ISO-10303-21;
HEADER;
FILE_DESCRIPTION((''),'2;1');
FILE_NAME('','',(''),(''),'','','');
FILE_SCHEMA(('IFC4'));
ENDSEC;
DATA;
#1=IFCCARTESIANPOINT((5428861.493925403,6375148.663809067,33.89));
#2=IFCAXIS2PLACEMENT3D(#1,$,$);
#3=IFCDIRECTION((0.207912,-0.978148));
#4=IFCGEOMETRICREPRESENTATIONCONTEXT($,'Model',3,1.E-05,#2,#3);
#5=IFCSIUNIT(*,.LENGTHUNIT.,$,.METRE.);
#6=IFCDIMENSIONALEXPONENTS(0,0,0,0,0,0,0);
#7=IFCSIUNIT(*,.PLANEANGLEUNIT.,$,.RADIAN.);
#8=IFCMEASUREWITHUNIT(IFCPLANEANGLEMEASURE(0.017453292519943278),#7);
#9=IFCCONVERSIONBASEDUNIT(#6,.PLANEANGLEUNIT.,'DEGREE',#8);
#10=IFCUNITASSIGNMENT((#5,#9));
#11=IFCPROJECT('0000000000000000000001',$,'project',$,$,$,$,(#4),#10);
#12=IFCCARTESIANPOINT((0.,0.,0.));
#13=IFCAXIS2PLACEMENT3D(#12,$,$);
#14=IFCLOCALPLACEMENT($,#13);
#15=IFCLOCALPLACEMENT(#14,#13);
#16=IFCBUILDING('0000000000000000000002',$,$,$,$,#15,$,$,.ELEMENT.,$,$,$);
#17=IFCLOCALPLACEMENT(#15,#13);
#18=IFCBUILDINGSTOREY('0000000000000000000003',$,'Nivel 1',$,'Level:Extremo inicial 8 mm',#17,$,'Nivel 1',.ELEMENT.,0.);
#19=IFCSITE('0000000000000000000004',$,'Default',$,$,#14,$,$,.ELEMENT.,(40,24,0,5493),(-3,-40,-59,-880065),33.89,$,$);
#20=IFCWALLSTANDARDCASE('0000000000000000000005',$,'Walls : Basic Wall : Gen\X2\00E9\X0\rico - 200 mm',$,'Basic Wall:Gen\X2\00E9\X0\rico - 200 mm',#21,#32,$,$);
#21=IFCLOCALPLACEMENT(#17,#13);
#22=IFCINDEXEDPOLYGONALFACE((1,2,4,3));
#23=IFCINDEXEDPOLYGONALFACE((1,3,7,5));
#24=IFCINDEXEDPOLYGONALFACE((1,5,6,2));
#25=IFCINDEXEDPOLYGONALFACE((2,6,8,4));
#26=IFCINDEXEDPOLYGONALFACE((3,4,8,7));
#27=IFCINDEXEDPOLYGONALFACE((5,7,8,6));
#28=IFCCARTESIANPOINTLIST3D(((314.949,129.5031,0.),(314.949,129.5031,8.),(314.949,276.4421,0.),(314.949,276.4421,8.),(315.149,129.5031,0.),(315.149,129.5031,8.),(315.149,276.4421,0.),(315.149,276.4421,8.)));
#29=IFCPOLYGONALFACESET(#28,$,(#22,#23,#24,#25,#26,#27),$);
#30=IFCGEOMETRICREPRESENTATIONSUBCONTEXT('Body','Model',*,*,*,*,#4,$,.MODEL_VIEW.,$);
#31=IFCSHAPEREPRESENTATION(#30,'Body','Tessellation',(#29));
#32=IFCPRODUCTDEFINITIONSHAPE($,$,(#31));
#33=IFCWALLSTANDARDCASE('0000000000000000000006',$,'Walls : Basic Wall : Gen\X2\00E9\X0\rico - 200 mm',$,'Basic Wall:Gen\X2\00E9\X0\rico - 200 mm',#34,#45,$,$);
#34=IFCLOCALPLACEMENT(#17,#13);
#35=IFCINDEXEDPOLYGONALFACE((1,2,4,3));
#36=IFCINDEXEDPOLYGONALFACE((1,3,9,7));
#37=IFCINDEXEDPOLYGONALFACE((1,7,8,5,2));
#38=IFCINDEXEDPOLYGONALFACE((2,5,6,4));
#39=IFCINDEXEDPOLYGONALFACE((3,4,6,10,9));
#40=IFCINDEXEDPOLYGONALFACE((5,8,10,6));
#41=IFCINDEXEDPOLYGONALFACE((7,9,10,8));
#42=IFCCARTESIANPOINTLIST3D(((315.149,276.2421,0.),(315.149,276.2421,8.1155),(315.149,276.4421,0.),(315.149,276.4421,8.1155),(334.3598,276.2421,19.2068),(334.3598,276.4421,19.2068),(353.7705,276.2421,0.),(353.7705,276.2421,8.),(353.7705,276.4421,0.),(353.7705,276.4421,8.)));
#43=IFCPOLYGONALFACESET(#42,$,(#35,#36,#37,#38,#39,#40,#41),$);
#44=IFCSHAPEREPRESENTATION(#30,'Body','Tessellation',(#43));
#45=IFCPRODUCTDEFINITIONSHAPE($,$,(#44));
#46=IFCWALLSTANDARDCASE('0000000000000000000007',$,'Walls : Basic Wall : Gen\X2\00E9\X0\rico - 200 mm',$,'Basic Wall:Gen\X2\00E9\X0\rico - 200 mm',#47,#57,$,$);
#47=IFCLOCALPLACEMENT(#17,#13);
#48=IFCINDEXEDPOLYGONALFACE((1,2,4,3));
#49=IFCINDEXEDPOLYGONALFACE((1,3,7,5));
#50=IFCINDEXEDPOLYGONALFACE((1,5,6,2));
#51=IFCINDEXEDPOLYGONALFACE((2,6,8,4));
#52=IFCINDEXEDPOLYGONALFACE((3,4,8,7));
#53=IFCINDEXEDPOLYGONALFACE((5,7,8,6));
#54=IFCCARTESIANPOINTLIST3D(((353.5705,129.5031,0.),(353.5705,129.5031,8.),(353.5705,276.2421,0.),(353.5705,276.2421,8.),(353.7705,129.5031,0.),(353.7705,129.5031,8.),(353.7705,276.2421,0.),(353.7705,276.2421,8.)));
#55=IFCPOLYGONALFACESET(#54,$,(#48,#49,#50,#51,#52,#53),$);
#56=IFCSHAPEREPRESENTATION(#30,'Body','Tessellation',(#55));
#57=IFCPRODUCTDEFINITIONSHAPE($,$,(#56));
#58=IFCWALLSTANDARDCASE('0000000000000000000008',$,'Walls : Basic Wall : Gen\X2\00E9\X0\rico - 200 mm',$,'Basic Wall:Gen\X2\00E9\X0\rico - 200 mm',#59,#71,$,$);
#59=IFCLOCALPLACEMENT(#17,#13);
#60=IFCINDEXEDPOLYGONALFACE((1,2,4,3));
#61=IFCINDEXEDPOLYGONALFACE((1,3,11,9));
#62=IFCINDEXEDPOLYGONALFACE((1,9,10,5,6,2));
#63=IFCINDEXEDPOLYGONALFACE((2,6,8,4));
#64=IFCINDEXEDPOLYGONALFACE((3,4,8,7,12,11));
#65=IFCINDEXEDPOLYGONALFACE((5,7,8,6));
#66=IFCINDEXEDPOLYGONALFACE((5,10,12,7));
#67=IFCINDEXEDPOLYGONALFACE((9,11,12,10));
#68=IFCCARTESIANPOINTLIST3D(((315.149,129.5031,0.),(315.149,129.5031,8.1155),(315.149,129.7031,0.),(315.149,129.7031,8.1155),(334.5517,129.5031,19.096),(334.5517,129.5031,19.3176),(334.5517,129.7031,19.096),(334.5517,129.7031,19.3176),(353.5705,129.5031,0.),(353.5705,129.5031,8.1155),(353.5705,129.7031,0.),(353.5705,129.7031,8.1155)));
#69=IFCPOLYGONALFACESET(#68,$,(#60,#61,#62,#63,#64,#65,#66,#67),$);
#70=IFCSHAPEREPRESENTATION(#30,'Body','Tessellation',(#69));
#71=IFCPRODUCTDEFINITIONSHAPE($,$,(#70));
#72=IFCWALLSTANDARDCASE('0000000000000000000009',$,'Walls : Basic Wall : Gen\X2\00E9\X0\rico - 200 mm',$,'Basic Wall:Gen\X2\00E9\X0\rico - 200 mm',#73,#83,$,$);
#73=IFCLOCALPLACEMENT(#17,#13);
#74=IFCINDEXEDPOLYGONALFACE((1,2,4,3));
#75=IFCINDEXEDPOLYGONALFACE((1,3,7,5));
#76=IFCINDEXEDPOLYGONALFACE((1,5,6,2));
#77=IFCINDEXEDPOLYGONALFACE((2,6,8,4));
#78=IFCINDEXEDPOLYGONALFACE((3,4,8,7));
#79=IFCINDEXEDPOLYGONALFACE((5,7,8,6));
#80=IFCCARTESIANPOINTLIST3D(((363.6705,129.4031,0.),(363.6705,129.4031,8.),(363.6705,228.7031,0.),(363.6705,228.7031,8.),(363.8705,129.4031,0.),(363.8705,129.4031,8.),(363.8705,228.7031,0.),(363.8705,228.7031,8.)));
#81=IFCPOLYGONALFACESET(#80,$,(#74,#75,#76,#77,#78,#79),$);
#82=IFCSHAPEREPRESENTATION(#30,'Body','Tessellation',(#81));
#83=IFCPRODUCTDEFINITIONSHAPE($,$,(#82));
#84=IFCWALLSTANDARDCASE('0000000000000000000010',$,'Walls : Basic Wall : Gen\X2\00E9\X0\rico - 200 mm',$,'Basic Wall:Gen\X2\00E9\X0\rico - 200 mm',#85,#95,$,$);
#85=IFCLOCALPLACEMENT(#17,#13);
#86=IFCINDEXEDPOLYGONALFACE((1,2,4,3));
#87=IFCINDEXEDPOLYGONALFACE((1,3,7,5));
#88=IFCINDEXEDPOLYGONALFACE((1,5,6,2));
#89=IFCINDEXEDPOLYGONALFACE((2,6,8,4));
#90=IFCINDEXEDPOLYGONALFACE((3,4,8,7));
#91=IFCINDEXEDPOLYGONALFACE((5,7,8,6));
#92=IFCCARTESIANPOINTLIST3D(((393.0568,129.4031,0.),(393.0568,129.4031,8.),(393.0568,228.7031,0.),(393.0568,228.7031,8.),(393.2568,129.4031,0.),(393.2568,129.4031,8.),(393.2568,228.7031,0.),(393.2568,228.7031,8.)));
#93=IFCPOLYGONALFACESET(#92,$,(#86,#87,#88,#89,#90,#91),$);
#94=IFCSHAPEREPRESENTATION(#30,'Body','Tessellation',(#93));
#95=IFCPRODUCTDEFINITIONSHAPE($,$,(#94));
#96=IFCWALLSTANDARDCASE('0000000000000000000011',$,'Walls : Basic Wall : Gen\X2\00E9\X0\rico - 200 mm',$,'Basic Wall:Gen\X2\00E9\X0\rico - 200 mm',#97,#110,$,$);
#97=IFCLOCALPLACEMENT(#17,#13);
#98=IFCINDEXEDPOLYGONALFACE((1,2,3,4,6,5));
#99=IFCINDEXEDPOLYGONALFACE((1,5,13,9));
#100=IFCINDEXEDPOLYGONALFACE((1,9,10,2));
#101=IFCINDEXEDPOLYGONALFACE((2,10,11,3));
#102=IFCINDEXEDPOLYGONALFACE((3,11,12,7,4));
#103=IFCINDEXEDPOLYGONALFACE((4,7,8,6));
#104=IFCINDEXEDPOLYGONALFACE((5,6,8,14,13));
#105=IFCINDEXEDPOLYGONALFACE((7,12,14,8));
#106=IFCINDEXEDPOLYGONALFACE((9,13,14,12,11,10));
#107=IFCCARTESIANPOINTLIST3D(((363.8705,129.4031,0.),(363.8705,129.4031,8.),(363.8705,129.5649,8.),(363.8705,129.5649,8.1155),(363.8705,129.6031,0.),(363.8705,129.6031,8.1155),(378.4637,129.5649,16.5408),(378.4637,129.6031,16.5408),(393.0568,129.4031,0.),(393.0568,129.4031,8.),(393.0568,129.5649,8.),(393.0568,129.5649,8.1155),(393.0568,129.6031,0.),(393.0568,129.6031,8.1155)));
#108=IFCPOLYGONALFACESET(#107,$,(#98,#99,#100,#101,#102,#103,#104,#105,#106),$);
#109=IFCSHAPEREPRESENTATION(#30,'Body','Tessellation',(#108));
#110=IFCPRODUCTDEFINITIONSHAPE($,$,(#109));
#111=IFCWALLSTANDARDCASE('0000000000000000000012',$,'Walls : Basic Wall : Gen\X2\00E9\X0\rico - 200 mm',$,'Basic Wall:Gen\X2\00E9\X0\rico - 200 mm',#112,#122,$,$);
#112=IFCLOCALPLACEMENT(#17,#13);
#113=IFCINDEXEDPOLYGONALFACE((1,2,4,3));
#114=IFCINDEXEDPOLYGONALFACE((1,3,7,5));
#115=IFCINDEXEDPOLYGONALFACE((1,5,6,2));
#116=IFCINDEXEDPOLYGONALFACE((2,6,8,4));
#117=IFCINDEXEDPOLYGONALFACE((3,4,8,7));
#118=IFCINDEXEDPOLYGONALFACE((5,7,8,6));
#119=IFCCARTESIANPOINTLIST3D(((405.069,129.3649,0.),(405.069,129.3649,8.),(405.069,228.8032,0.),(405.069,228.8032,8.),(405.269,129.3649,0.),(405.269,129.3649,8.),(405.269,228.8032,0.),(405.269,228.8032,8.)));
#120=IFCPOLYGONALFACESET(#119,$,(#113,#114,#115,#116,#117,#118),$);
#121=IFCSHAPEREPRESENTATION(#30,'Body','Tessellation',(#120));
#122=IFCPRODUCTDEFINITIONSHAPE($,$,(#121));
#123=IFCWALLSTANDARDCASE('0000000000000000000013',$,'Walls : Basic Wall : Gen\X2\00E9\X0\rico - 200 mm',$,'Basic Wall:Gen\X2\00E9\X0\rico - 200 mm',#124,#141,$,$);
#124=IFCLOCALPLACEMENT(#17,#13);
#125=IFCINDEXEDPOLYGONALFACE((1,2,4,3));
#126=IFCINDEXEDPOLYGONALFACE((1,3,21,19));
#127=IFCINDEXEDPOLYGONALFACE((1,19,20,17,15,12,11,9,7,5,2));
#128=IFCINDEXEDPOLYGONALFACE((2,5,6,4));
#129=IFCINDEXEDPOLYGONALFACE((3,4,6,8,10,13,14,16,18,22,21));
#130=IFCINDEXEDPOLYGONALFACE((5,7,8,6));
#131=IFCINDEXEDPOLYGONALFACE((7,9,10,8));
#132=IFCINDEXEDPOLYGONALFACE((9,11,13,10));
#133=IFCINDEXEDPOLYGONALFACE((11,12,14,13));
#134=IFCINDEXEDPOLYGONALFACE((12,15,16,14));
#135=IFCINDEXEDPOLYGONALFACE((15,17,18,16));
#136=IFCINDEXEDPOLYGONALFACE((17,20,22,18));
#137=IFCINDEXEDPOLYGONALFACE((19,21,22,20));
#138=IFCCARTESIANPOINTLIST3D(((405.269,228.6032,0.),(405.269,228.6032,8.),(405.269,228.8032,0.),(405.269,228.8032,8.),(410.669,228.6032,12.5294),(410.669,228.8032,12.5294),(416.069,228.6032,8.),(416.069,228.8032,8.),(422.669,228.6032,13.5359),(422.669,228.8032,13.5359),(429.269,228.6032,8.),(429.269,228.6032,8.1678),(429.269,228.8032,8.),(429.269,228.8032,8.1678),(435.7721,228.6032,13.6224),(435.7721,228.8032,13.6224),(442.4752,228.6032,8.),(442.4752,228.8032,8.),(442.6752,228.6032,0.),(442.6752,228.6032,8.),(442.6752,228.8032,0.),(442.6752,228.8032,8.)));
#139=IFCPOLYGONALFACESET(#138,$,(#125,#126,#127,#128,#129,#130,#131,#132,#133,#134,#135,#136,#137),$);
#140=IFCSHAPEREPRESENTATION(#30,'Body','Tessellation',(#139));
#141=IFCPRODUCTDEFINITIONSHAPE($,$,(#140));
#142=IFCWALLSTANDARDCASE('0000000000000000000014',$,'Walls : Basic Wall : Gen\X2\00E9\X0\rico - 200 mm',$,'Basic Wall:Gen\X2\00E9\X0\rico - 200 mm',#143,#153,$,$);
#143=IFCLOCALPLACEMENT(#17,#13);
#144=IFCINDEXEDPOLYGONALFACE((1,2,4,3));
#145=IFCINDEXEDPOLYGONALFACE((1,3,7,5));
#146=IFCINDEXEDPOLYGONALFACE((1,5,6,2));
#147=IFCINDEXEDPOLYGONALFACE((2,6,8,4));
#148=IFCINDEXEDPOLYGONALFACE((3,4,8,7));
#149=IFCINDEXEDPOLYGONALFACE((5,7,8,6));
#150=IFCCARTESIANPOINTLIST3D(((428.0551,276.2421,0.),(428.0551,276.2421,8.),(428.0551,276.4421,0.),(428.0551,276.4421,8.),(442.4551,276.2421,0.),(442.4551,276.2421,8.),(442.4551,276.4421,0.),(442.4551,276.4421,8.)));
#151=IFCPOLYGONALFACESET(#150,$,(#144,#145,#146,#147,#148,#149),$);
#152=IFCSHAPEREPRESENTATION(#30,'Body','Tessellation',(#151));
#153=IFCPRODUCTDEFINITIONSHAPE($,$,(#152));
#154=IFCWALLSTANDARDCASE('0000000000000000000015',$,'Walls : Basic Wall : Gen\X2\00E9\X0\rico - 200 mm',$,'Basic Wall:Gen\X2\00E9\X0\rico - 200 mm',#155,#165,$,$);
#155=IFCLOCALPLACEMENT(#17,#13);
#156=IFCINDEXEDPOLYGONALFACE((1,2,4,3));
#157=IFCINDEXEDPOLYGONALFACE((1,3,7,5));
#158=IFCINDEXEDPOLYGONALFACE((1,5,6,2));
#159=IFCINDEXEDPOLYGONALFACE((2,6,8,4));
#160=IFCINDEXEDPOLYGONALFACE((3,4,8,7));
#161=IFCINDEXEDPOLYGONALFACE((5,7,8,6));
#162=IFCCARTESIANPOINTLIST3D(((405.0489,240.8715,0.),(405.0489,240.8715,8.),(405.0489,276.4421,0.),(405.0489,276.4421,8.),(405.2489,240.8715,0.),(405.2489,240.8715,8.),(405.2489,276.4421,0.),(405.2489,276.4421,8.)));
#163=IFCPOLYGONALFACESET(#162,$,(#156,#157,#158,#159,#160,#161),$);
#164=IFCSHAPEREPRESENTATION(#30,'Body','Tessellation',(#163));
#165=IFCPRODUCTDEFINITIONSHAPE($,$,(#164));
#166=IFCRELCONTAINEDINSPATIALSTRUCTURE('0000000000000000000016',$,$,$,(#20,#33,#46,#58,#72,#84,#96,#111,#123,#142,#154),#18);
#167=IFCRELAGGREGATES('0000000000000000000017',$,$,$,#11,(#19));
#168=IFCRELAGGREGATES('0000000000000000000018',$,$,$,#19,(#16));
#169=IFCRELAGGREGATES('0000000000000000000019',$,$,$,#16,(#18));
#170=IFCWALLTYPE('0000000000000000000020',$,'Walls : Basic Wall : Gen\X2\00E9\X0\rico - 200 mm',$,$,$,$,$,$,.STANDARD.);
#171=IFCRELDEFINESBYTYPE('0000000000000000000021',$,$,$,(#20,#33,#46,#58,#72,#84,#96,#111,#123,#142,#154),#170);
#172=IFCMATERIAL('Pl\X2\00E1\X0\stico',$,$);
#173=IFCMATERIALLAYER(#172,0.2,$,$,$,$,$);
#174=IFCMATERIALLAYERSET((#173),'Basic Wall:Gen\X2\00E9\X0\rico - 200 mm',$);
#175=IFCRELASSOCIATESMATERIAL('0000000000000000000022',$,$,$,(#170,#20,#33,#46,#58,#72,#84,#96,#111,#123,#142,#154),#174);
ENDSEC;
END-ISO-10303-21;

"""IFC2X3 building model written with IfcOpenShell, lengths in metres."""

from ifc_helpers import new_model, entity, si_unit, converted_unit, direction, frame, frame_2d, origin, place, context, subcontext, project, spatial, polyline, rectangle, extrude, clip, bounded_halfspace, material, layer, layer_set, layer_usage, type_object, element, save


model = new_model("IFC2X3")

# Units and contexts
model_context = context("Model", 3, precision=1e-05, world=frame((5428861.493925403, 6375148.663809067, 33.89)), true_north=direction((0.207912, -0.978148)))
body_context = subcontext(model_context, "Body", "Model", "MODEL_VIEW")
ifc_project = project(units=[si_unit("LENGTHUNIT", "METRE"), converted_unit("PLANEANGLEUNIT", "DEGREE", entity("IfcPlaneAngleMeasure", 0.017453292519943278), si_unit("PLANEANGLEUNIT", "RADIAN"), dimensions=[0, 0, 0, 0, 0, 0, 0])], contexts=[model_context])

# Site, building, storey
site_placement = place(None, origin())
site = spatial("IfcSite", under=ifc_project, at=site_placement, Name="Default", CompositionType="ELEMENT", RefLatitude=(40, 24, 0, 5493), RefLongitude=(-3, -40, -59, -880065), RefElevation=33.89)
building_placement = place(site_placement, origin())
building = spatial("IfcBuilding", under=site, at=building_placement, CompositionType="ELEMENT")
storey_placement = place(building_placement, origin())
storey = spatial("IfcBuildingStorey", under=building, at=storey_placement, Name="Nivel 1", ObjectType="Level:Extremo inicial 8 mm", LongName="Nivel 1", CompositionType="ELEMENT", Elevation=0.0)

# Walls
ifc_material = material(Name="Plástico")
ifc_layer = layer(ifc_material, 0.2)
ifc_layer_set = layer_set([ifc_layer], Name="Basic Wall:Genérico - 200 mm")
ifc_layer_usage_1 = layer_usage(ifc_layer_set, "AXIS2", "NEGATIVE", 0.1)
wall_type = type_object("IfcWallType", Name="Walls : Basic Wall : Genérico - 200 mm", PredefinedType="STANDARD", material=ifc_layer_set)
wall_1_placement = place(storey_placement, frame((315.049, 129.5031, 0.0), z_axis=(0.0, 0.0, 1.0), x_axis=(0.0, 1.0, 0.0)))
element("IfcWallStandardCase", 1, at=wall_1_placement, inside=storey, type_object=wall_type, material=ifc_layer_usage_1, Name="Walls : Basic Wall : Genérico - 200 mm", ObjectType="Basic Wall:Genérico - 200 mm", context=body_context, shape_type="SweptSolid", body=[
    extrude(rectangle(XDim=146.9389, YDim=0.2, at=frame_2d((73.4695, 0.0), x_axis=(-1.0, 0.0))), origin(), (0.0, 0.0, 1.0), 8.0),
])
ifc_layer_usage_2 = layer_usage(ifc_layer_set, "AXIS2", "NEGATIVE", 0.1)
wall_2_placement = place(storey_placement, frame((315.149, 276.3421, 0.0)))
element("IfcWallStandardCase", 2, at=wall_2_placement, inside=storey, type_object=wall_type, material=ifc_layer_usage_2, Name="Walls : Basic Wall : Genérico - 200 mm", ObjectType="Basic Wall:Genérico - 200 mm", context=body_context, shape_type="Clipping", body=[
    clip(clip(extrude(rectangle(XDim=38.6216, YDim=0.2, at=frame_2d((19.3108, 0.0), x_axis=(-1.0, 0.0))), origin(), (0.0, 0.0, 1.0), 19.2068), bounded_halfspace(frame((0.0, -0.1, 8.1155), z_axis=(-0.5, 0.0, 0.866025), x_axis=(0.0, -1.0, 0.0)), False, frame((0.0, -0.1, 8.1155)), polyline([(0.0, 0.0), (19.2108, 0.0), (19.2108, 0.2), (0.0, 0.2), (0.0, 0.0)]))), bounded_halfspace(frame((19.2108, -0.1, 19.2068), z_axis=(0.5, 0.0, 0.866025), x_axis=(0.0, 1.0, 0.0)), False, frame((19.2108, -0.1, 19.2068)), polyline([(0.0, 0.0), (19.4108, 0.0), (19.4108, 0.2), (0.0, 0.2), (0.0, 0.0)]))),
])
ifc_layer_usage_3 = layer_usage(ifc_layer_set, "AXIS2", "NEGATIVE", 0.1)
wall_3_placement = place(storey_placement, frame((353.6705, 276.2421, 0.0), z_axis=(0.0, 0.0, 1.0), x_axis=(0.0, -1.0, 0.0)))
element("IfcWallStandardCase", 3, at=wall_3_placement, inside=storey, type_object=wall_type, material=ifc_layer_usage_3, Name="Walls : Basic Wall : Genérico - 200 mm", ObjectType="Basic Wall:Genérico - 200 mm", context=body_context, shape_type="SweptSolid", body=[
    extrude(rectangle(XDim=146.7389, YDim=0.2, at=frame_2d((73.3695, 0.0), x_axis=(-1.0, 0.0))), origin(), (0.0, 0.0, 1.0), 8.0),
])
ifc_layer_usage_4 = layer_usage(ifc_layer_set, "AXIS2", "NEGATIVE", 0.1)
wall_4_placement = place(storey_placement, frame((353.5705, 129.6031, 0.0), z_axis=(0.0, 0.0, 1.0), x_axis=(-1.0, 0.0, 0.0)))
element("IfcWallStandardCase", 4, at=wall_4_placement, inside=storey, type_object=wall_type, material=ifc_layer_usage_4, Name="Walls : Basic Wall : Genérico - 200 mm", ObjectType="Basic Wall:Genérico - 200 mm", context=body_context, shape_type="Clipping", body=[
    clip(clip(extrude(rectangle(XDim=38.4216, YDim=0.2, at=frame_2d((19.2108, 0.0), x_axis=(-1.0, 0.0))), origin(), (0.0, 0.0, 1.0), 19.3176), bounded_halfspace(frame((19.0188, -0.1, 19.3176), z_axis=(0.5, 0.0, 0.866025), x_axis=(0.0, 1.0, 0.0)), False, frame((19.0188, -0.1, 19.3176)), polyline([(0.0, 0.0), (19.4027, 0.0), (19.4027, 0.2), (0.0, 0.2), (0.0, 0.0)]))), bounded_halfspace(frame((0.0, -0.1, 8.1155), z_axis=(-0.5, 0.0, 0.866025), x_axis=(0.0, -1.0, 0.0)), False, frame((0.0, -0.1, 8.1155)), polyline([(0.0, 0.0), (19.0188, 0.0), (19.0188, 0.2), (0.0, 0.2), (0.0, 0.0)]))),
])
ifc_layer_usage_5 = layer_usage(ifc_layer_set, "AXIS2", "NEGATIVE", 0.1)
wall_5_placement = place(storey_placement, frame((363.7705, 129.4031, 0.0), z_axis=(0.0, 0.0, 1.0), x_axis=(0.0, 1.0, 0.0)))
element("IfcWallStandardCase", 5, at=wall_5_placement, inside=storey, type_object=wall_type, material=ifc_layer_usage_5, Name="Walls : Basic Wall : Genérico - 200 mm", ObjectType="Basic Wall:Genérico - 200 mm", context=body_context, shape_type="SweptSolid", body=[
    extrude(rectangle(XDim=99.3, YDim=0.2, at=frame_2d((49.65, 0.0), x_axis=(-1.0, 0.0))), origin(), (0.0, 0.0, 1.0), 8.0),
])
ifc_layer_usage_6 = layer_usage(ifc_layer_set, "AXIS2", "NEGATIVE", 0.1)
wall_6_placement = place(storey_placement, frame((393.1568, 228.7031, 0.0), z_axis=(0.0, 0.0, 1.0), x_axis=(0.0, -1.0, 0.0)))
element("IfcWallStandardCase", 6, at=wall_6_placement, inside=storey, type_object=wall_type, material=ifc_layer_usage_6, Name="Walls : Basic Wall : Genérico - 200 mm", ObjectType="Basic Wall:Genérico - 200 mm", context=body_context, shape_type="SweptSolid", body=[
    extrude(rectangle(XDim=99.3, YDim=0.2, at=frame_2d((49.65, 0.0), x_axis=(-1.0, 0.0))), origin(), (0.0, 0.0, 1.0), 8.0),
])
ifc_layer_usage_7 = layer_usage(ifc_layer_set, "AXIS2", "NEGATIVE", 0.1)
wall_7_placement = place(storey_placement, frame((393.0568, 129.5031, 0.0), z_axis=(0.0, 0.0, 1.0), x_axis=(-1.0, 0.0, 0.0)))
element("IfcWallStandardCase", 7, at=wall_7_placement, inside=storey, type_object=wall_type, material=ifc_layer_usage_7, Name="Walls : Basic Wall : Genérico - 200 mm", ObjectType="Basic Wall:Genérico - 200 mm", context=body_context, shape_type="Clipping", body=[
    clip(clip(clip(extrude(rectangle(XDim=29.1863, YDim=0.2, at=frame_2d((14.5931, 0.0), x_axis=(-1.0, 0.0))), origin(), (0.0, 0.0, 1.0), 16.5408), bounded_halfspace(frame((14.5931, -0.1, 16.5408), z_axis=(0.5, 0.0, 0.866025), x_axis=(0.0, 1.0, 0.0)), False, frame((14.5931, -0.1, 16.5408)), polyline([(0.0, 0.0), (14.5931, 0.0), (14.5931, 0.0382), (0.0, 0.0382), (0.0, 0.0)]))), bounded_halfspace(frame((0.0, -0.1, 8.1155), z_axis=(-0.5, 0.0, 0.866025), x_axis=(0.0, -1.0, 0.0)), False, frame((0.0, -0.1, 8.1155)), polyline([(0.0, 0.0), (14.5931, 0.0), (14.5931, 0.0382), (0.0, 0.0382), (0.0, 0.0)]))), bounded_halfspace(frame((29.1863, -0.0618, 8.0), z_axis=(0.0, 0.0, 1.0), x_axis=(0.0, 1.0, 0.0)), False, frame((29.1863, -0.0618, 8.0)), polyline([(0.0, 0.0), (0.0, 0.1618), (-29.1863, 0.1618), (-29.1863, 0.0), (0.0, 0.0)]))),
])
ifc_layer_usage_8 = layer_usage(ifc_layer_set, "AXIS2", "NEGATIVE", 0.1)
wall_8_placement = place(storey_placement, frame((405.169, 129.3649, 0.0), z_axis=(0.0, 0.0, 1.0), x_axis=(0.0, 1.0, 0.0)))
element("IfcWallStandardCase", 8, at=wall_8_placement, inside=storey, type_object=wall_type, material=ifc_layer_usage_8, Name="Walls : Basic Wall : Genérico - 200 mm", ObjectType="Basic Wall:Genérico - 200 mm", context=body_context, shape_type="SweptSolid", body=[
    extrude(rectangle(XDim=99.4383, YDim=0.2, at=frame_2d((49.7191, 0.0), x_axis=(-1.0, 0.0))), origin(), (0.0, 0.0, 1.0), 8.0),
])
ifc_layer_usage_9 = layer_usage(ifc_layer_set, "AXIS2", "NEGATIVE", 0.1)
wall_9_placement = place(storey_placement, frame((405.269, 228.7032, 0.0)))
element("IfcWallStandardCase", 9, at=wall_9_placement, inside=storey, type_object=wall_type, material=ifc_layer_usage_9, Name="Walls : Basic Wall : Genérico - 200 mm", ObjectType="Basic Wall:Genérico - 200 mm", context=body_context, shape_type="Clipping", body=[
    clip(clip(clip(clip(clip(clip(clip(extrude(rectangle(XDim=37.4062, YDim=0.2, at=frame_2d((18.7031, 0.0), x_axis=(-1.0, 0.0))), origin(), (0.0, 0.0, 1.0), 13.6224), bounded_halfspace(frame((24.0, -0.1, 8.1678), z_axis=(-0.642641, 0.0, 0.766167), x_axis=(0.0, -1.0, 0.0)), False, frame((24.0, -0.1, 8.1678)), polyline([(0.0, 0.0), (6.5031, 0.0), (6.5031, 0.2), (0.0, 0.2), (0.0, 0.0)]))), bounded_halfspace(frame((17.4, 0.1, 13.5359), z_axis=(-0.642641, 0.0, 0.766167), x_axis=(0.0, -1.0, 0.0)), False, frame((17.4, 0.1, 13.5359)), polyline([(0.0, 0.0), (-6.6, 0.0), (-6.6, -0.2), (0.0, -0.2), (0.0, 0.0)]))), bounded_halfspace(frame((0.0, -0.1, 8.0), z_axis=(-0.642641, 0.0, 0.766167), x_axis=(0.0, -1.0, 0.0)), False, frame((0.0, -0.1, 8.0)), polyline([(0.0, 0.0), (5.4, 0.0), (5.4, 0.2), (0.0, 0.2), (0.0, 0.0)]))), bounded_halfspace(frame((30.5031, -0.1, 13.6224), z_axis=(0.642641, 0.0, 0.766167), x_axis=(0.0, 1.0, 0.0)), False, frame((30.5031, -0.1, 13.6224)), polyline([(0.0, 0.0), (6.7031, 0.0), (6.7031, 0.2), (0.0, 0.2), (0.0, 0.0)]))), bounded_halfspace(frame((24.0, -0.1, 8.0), z_axis=(0.642641, 0.0, 0.766167), x_axis=(0.0, 1.0, 0.0)), False, frame((24.0, -0.1, 8.0)), polyline([(0.0, 0.0), (0.0, 0.2), (-6.6, 0.2), (-6.6, 0.0), (0.0, 0.0)]))), bounded_halfspace(frame((5.4, -0.1, 12.5294), z_axis=(0.642641, 0.0, 0.766167), x_axis=(0.0, 1.0, 0.0)), False, frame((5.4, -0.1, 12.5294)), polyline([(0.0, 0.0), (5.4, 0.0), (5.4, 0.2), (0.0, 0.2), (0.0, 0.0)]))), bounded_halfspace(frame((37.2062, -0.1, 8.0), z_axis=(0.0, 0.0, 1.0), x_axis=(0.0, 1.0, 0.0)), False, frame((37.2062, -0.1, 8.0)), polyline([(0.0, 0.0), (0.2, 0.0), (0.2, 0.2), (0.0, 0.2), (0.0, 0.0)]))),
])
ifc_layer_usage_10 = layer_usage(ifc_layer_set, "AXIS2", "NEGATIVE", 0.1)
wall_10_placement = place(storey_placement, frame((428.0551, 276.3421, 0.0)))
element("IfcWallStandardCase", 10, at=wall_10_placement, inside=storey, type_object=wall_type, material=ifc_layer_usage_10, Name="Walls : Basic Wall : Genérico - 200 mm", ObjectType="Basic Wall:Genérico - 200 mm", context=body_context, shape_type="SweptSolid", body=[
    extrude(rectangle(XDim=14.4, YDim=0.2, at=frame_2d((7.2, 0.0), x_axis=(-1.0, 0.0))), origin(), (0.0, 0.0, 1.0), 8.0),
])
ifc_layer_usage_11 = layer_usage(ifc_layer_set, "AXIS2", "NEGATIVE", 0.1)
wall_11_placement = place(storey_placement, frame((405.1489, 240.8715, 0.0), z_axis=(0.0, 0.0, 1.0), x_axis=(0.0, 1.0, 0.0)))
element("IfcWallStandardCase", 11, at=wall_11_placement, inside=storey, type_object=wall_type, material=ifc_layer_usage_11, Name="Walls : Basic Wall : Genérico - 200 mm", ObjectType="Basic Wall:Genérico - 200 mm", context=body_context, shape_type="SweptSolid", body=[
    extrude(rectangle(XDim=35.5706, YDim=0.2, at=frame_2d((17.7853, 0.0), x_axis=(-1.0, 0.0))), origin(), (0.0, 0.0, 1.0), 8.0),
])

save(model, "model.ifc")
